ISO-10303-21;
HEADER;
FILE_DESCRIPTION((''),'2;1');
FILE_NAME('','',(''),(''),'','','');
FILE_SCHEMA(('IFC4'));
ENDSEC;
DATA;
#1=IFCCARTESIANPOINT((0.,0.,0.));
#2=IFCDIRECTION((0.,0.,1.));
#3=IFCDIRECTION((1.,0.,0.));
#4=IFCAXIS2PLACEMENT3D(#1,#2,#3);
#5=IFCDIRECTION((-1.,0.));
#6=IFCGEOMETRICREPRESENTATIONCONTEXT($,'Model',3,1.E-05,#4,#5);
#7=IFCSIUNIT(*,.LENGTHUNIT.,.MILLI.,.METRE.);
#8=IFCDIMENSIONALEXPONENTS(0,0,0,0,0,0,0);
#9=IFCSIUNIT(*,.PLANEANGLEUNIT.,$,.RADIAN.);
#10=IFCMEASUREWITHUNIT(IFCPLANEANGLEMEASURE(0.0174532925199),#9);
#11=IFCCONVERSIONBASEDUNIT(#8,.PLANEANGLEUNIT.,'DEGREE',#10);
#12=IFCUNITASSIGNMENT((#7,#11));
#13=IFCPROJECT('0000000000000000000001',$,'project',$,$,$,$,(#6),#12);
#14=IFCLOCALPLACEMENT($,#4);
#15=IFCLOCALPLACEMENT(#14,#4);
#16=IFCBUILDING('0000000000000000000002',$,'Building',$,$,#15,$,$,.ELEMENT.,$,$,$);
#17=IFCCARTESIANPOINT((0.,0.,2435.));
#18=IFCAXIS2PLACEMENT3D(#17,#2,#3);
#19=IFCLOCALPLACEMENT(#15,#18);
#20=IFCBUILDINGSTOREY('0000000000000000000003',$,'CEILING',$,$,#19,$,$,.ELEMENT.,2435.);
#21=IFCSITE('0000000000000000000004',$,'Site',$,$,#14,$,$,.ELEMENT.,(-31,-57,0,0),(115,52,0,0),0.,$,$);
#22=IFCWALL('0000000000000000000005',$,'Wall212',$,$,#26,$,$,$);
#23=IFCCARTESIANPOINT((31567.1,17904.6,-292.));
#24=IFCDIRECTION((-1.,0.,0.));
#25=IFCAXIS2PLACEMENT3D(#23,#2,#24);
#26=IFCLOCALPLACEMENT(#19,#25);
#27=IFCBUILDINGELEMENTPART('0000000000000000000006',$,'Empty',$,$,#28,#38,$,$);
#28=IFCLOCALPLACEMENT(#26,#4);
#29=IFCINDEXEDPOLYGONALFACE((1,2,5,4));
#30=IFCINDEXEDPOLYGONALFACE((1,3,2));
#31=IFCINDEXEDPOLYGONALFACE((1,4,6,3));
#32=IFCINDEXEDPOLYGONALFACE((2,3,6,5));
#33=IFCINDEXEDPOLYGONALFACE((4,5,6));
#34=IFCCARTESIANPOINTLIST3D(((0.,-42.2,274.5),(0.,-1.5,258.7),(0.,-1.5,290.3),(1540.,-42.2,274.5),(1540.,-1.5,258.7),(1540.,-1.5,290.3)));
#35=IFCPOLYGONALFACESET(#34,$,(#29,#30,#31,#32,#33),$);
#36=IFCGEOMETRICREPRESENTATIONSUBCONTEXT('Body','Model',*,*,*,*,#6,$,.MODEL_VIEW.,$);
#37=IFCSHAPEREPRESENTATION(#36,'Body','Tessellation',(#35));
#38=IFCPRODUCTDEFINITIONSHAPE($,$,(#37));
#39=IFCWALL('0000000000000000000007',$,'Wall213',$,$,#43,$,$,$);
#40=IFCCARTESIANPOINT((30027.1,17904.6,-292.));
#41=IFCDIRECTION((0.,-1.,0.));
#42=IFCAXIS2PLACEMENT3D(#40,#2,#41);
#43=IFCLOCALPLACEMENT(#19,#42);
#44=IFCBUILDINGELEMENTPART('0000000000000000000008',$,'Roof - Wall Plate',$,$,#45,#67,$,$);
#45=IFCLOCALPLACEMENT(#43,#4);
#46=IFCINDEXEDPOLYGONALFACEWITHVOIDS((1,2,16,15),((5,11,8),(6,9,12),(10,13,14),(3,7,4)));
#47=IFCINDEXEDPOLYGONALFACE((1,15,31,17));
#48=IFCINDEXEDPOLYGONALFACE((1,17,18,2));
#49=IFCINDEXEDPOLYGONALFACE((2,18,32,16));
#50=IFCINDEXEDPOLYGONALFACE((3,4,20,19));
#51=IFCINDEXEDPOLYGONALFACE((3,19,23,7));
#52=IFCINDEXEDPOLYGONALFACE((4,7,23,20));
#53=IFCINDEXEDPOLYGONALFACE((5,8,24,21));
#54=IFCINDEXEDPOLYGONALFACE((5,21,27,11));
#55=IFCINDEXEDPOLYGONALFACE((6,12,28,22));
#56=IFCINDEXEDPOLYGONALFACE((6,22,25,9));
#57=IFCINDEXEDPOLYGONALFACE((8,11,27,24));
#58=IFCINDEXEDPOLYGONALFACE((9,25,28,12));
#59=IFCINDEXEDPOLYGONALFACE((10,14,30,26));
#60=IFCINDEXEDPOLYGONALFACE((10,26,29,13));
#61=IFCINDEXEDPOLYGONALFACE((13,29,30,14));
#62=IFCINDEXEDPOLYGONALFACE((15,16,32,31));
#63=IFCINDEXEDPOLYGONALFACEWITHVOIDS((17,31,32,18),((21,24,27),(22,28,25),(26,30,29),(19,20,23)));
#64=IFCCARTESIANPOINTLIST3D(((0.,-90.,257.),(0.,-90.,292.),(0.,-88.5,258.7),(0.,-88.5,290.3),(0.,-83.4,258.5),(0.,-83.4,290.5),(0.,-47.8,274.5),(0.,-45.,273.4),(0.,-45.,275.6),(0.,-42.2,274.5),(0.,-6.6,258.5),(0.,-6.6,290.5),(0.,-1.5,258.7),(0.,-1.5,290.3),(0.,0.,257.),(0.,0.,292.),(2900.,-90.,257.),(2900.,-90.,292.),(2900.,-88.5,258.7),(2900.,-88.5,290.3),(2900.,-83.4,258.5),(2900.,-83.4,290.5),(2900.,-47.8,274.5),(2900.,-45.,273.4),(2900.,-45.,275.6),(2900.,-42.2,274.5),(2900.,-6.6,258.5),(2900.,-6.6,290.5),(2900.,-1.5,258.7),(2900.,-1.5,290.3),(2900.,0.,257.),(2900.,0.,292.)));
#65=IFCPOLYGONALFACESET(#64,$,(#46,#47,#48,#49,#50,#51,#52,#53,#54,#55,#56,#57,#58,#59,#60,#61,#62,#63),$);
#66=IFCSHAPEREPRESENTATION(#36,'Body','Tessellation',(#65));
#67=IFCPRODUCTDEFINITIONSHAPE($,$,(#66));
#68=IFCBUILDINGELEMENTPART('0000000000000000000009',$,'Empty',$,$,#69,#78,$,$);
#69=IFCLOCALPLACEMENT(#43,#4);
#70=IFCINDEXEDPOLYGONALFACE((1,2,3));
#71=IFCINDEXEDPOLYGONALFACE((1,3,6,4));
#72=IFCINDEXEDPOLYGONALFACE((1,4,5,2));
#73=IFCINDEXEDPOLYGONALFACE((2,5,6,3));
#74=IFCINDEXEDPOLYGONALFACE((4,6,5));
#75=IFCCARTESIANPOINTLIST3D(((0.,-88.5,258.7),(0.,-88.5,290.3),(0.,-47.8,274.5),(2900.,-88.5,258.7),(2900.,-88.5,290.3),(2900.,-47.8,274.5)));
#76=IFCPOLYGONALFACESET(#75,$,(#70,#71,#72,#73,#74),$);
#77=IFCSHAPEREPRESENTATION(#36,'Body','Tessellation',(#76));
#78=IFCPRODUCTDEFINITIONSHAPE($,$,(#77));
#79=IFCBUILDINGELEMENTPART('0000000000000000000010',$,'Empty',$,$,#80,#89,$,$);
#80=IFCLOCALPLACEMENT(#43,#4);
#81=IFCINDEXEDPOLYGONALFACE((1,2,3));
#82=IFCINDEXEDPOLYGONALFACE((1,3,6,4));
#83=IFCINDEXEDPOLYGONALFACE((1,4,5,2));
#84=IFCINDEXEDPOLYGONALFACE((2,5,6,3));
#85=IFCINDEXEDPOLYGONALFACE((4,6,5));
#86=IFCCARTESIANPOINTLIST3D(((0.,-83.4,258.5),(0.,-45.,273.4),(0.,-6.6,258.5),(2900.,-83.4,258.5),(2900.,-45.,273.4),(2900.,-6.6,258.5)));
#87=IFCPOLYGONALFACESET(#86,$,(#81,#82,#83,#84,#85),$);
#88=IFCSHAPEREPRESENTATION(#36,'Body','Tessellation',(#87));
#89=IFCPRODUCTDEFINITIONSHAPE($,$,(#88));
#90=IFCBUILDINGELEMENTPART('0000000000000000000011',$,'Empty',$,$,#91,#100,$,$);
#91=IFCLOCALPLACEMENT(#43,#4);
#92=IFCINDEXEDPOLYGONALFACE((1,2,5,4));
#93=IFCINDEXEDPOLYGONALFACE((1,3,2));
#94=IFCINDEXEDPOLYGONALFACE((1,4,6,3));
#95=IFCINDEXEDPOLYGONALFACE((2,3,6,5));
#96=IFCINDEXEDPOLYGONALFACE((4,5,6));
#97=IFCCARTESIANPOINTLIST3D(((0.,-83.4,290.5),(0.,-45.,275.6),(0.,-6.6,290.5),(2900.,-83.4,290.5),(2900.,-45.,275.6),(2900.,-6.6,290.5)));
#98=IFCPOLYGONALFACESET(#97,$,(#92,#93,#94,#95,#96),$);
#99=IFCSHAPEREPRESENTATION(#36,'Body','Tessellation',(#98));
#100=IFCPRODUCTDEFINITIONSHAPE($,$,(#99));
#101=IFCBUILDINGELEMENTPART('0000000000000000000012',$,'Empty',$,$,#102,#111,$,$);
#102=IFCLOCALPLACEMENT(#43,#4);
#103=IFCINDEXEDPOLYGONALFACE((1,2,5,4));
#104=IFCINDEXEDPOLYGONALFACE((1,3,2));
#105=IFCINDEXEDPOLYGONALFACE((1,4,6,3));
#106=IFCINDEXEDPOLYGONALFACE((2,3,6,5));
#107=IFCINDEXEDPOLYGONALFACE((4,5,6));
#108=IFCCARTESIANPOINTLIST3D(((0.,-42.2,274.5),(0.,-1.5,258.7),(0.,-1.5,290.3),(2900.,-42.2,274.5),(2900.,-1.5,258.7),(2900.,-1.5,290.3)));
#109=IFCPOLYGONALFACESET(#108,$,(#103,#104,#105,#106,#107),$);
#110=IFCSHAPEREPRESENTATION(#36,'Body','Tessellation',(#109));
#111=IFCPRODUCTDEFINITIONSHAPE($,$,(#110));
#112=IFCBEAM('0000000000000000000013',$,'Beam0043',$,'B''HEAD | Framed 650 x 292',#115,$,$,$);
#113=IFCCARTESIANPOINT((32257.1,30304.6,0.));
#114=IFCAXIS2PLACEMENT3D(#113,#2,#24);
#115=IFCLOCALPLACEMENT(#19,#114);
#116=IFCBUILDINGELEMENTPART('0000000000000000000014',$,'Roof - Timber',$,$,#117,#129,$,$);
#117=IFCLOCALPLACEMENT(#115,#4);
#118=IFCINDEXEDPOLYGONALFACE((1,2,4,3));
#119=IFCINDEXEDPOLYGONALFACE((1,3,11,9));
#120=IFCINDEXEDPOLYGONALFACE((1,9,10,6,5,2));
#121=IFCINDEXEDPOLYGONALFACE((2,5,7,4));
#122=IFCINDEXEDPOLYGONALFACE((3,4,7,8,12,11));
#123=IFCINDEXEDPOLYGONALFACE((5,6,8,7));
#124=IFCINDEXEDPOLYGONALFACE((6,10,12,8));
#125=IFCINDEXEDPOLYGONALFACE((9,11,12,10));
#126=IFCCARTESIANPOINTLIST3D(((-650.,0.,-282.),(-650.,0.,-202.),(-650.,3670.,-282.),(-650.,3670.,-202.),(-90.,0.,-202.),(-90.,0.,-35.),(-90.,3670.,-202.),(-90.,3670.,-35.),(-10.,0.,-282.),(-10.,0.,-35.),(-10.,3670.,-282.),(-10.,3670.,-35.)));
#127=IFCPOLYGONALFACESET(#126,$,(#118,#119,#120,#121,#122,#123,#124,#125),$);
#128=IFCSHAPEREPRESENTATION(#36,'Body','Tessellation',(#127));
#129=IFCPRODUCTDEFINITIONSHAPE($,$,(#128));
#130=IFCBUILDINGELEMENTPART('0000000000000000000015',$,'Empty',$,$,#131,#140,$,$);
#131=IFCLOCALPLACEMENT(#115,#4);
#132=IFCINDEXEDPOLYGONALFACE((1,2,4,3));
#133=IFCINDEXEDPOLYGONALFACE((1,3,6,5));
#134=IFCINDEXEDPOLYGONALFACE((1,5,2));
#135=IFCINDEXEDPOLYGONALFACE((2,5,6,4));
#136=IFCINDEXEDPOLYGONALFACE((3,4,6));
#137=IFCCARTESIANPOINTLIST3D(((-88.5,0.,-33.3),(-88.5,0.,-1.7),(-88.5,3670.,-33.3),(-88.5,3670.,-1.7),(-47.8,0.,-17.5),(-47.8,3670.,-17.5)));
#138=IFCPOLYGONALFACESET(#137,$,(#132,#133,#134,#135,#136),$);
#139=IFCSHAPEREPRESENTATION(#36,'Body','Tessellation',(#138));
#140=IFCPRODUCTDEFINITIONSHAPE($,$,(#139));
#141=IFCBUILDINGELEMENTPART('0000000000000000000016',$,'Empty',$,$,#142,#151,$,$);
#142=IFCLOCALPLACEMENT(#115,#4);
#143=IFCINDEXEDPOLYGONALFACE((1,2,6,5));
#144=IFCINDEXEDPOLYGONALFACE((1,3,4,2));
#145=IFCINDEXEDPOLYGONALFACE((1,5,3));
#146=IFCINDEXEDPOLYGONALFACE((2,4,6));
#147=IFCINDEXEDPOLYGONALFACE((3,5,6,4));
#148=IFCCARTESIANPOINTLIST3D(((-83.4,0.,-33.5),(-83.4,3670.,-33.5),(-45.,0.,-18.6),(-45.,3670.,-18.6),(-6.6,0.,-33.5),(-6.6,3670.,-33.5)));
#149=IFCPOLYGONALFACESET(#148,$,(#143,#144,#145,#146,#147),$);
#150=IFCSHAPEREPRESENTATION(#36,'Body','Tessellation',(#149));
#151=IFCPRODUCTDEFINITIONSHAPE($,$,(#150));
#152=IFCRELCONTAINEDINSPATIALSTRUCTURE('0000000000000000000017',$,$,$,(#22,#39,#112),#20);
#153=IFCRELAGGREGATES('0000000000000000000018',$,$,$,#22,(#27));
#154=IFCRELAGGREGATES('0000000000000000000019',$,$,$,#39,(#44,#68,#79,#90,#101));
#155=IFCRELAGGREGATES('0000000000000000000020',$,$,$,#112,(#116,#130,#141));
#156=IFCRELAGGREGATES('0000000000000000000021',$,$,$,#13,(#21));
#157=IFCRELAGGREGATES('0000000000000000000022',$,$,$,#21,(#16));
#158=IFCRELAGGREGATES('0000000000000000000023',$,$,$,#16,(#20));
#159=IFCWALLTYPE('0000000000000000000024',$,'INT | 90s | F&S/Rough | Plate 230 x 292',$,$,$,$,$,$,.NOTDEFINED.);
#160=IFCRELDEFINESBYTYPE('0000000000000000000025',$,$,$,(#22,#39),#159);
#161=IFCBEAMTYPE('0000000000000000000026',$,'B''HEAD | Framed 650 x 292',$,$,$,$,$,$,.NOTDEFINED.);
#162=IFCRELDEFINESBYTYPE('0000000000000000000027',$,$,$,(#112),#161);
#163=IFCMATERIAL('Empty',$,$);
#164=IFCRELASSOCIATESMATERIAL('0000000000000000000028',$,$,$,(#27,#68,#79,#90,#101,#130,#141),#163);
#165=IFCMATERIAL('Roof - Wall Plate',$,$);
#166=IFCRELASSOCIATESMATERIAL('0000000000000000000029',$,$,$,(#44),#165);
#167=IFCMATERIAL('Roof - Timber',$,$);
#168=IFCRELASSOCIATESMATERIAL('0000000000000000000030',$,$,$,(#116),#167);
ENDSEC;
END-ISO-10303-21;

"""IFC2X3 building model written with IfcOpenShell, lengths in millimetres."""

from ifc_helpers import new_model, entity, si_unit, converted_unit, direction, frame, origin_with_axes, place, context, subcontext, project, spatial, polyline, outline, extrude, material, type_object, element, aggregate, save


model = new_model("IFC2X3")

# Units and contexts
model_context = context("Model", 3, precision=1e-05, world=origin_with_axes(), true_north=direction((-1.0, 0.0)))
body_context = subcontext(model_context, "Body", "Model", "MODEL_VIEW")
ifc_project = project(units=[si_unit("LENGTHUNIT", "METRE", prefix="MILLI"), converted_unit("PLANEANGLEUNIT", "DEGREE", entity("IfcPlaneAngleMeasure", 0.0174532925199), si_unit("PLANEANGLEUNIT", "RADIAN"), dimensions=[0, 0, 0, 0, 0, 0, 0])], contexts=[model_context])

# Site, building, storey
site_placement = place(None, origin_with_axes())
site = spatial("IfcSite", under=ifc_project, at=site_placement, Name="Site", CompositionType="ELEMENT", RefLatitude=(-31, -57, 0, 0), RefLongitude=(115, 52, 0, 0), RefElevation=0.0)
building_placement = place(site_placement, origin_with_axes())
building = spatial("IfcBuilding", under=site, at=building_placement, Name="Building", CompositionType="ELEMENT")
storey_placement = place(building_placement, frame((0.0, 0.0, 2435.0), z_axis=(0.0, 0.0, 1.0), x_axis=(1.0, 0.0, 0.0)))
storey = spatial("IfcBuildingStorey", under=building, at=storey_placement, Name="CEILING", CompositionType="ELEMENT", Elevation=2435.0)

# Shared definitions
ifc_material_1 = material(Name="Roof - Timber")

# Walls, building element parts
wall_type = type_object("IfcWallType", Name="INT | 90s | F&S/Rough | Plate 230 x 292", PredefinedType="NOTDEFINED")
wall_1_placement = place(storey_placement, frame((31567.1, 17904.6, -292.0), z_axis=(0.0, 0.0, 1.0), x_axis=(-1.0, 0.0, 0.0)))
wall_1 = element("IfcWall", 1, at=wall_1_placement, inside=storey, type_object=wall_type, Name="Wall212")
ifc_material_2 = material(Name="Empty")
building_element_part_1_placement = place(wall_1_placement, origin_with_axes())
building_element_part_1 = element("IfcBuildingElementPart", 2, at=building_element_part_1_placement, material=ifc_material_2, Name="Empty", context=body_context, shape_type="SweptSolid", body=[
    extrude(outline(polyline([(-42.2, 274.5), (-1.5, 258.7), (-1.5, 290.3), (-42.2, 274.5)])), frame((0.0, 0.0, 0.0), z_axis=(1.0, 0.0, 0.0), x_axis=(0.0, 1.0, 0.0)), (0.0, 0.0, 1.0), 1540.0),
])
aggregate(wall_1, [building_element_part_1])
wall_2_placement = place(storey_placement, frame((30027.1, 17904.6, -292.0), z_axis=(0.0, 0.0, 1.0), x_axis=(0.0, -1.0, 0.0)))
wall_2 = element("IfcWall", 3, at=wall_2_placement, inside=storey, type_object=wall_type, Name="Wall213")
ifc_material_3 = material(Name="Roof - Wall Plate")
building_element_part_2_placement = place(wall_2_placement, origin_with_axes())
building_element_part_2 = element("IfcBuildingElementPart", 4, at=building_element_part_2_placement, material=ifc_material_3, Name="Roof - Wall Plate", context=body_context, shape_type="SweptSolid", body=[
    extrude(outline(polyline([(-90.0, 257.0), (0.0, 257.0), (0.0, 292.0), (-90.0, 292.0), (-90.0, 257.0)]), holes=[polyline([(-83.4, 290.5), (-6.6, 290.5), (-45.0, 275.6), (-83.4, 290.5)]), polyline([(-42.2, 274.5), (-1.5, 290.3), (-1.5, 258.7), (-42.2, 274.5)]), polyline([(-6.6, 258.5), (-83.4, 258.5), (-45.0, 273.4), (-6.6, 258.5)]), polyline([(-88.5, 258.7), (-88.5, 290.3), (-47.8, 274.5), (-88.5, 258.7)])]), frame((0.0, 0.0, 0.0), z_axis=(1.0, 0.0, 0.0), x_axis=(0.0, 1.0, 0.0)), (0.0, 0.0, 1.0), 2900.0),
])
building_element_part_3_placement = place(wall_2_placement, origin_with_axes())
building_element_part_3 = element("IfcBuildingElementPart", 5, at=building_element_part_3_placement, material=ifc_material_2, Name="Empty", context=body_context, shape_type="SweptSolid", body=[
    extrude(outline(polyline([(-47.8, 274.5), (-88.5, 290.3), (-88.5, 258.7), (-47.8, 274.5)])), frame((0.0, 0.0, 0.0), z_axis=(1.0, 0.0, 0.0), x_axis=(0.0, 1.0, 0.0)), (0.0, 0.0, 1.0), 2900.0),
])
building_element_part_4_placement = place(wall_2_placement, origin_with_axes())
building_element_part_4 = element("IfcBuildingElementPart", 6, at=building_element_part_4_placement, material=ifc_material_2, Name="Empty", context=body_context, shape_type="SweptSolid", body=[
    extrude(outline(polyline([(-6.6, 258.5), (-45.0, 273.4), (-83.4, 258.5), (-6.6, 258.5)])), frame((0.0, 0.0, 0.0), z_axis=(1.0, 0.0, 0.0), x_axis=(0.0, 1.0, 0.0)), (0.0, 0.0, 1.0), 2900.0),
])
building_element_part_5_placement = place(wall_2_placement, origin_with_axes())
building_element_part_5 = element("IfcBuildingElementPart", 7, at=building_element_part_5_placement, material=ifc_material_2, Name="Empty", context=body_context, shape_type="SweptSolid", body=[
    extrude(outline(polyline([(-45.0, 275.6), (-6.6, 290.5), (-83.4, 290.5), (-45.0, 275.6)])), frame((0.0, 0.0, 0.0), z_axis=(1.0, 0.0, 0.0), x_axis=(0.0, 1.0, 0.0)), (0.0, 0.0, 1.0), 2900.0),
])
building_element_part_6_placement = place(wall_2_placement, origin_with_axes())
building_element_part_6 = element("IfcBuildingElementPart", 8, at=building_element_part_6_placement, material=ifc_material_2, Name="Empty", context=body_context, shape_type="SweptSolid", body=[
    extrude(outline(polyline([(-42.2, 274.5), (-1.5, 258.7), (-1.5, 290.3), (-42.2, 274.5)])), frame((0.0, 0.0, 0.0), z_axis=(1.0, 0.0, 0.0), x_axis=(0.0, 1.0, 0.0)), (0.0, 0.0, 1.0), 2900.0),
])
aggregate(wall_2, [building_element_part_2, building_element_part_3, building_element_part_4, building_element_part_5, building_element_part_6])

# Beam, building element parts
beam_type = type_object("IfcBeamType", Name="B'HEAD | Framed 650 x 292", PredefinedType="NOTDEFINED")
beam_placement = place(storey_placement, frame((32257.1, 30304.6, 0.0), z_axis=(0.0, 0.0, 1.0), x_axis=(-1.0, 0.0, 0.0)))
beam = element("IfcBeam", 9, at=beam_placement, inside=storey, type_object=beam_type, Name="Beam0043", ObjectType="B'HEAD | Framed 650 x 292")
building_element_part_7_placement = place(beam_placement, origin_with_axes())
building_element_part_7 = element("IfcBuildingElementPart", 10, at=building_element_part_7_placement, material=ifc_material_1, Name="Roof - Timber", context=body_context, shape_type="SweptSolid", body=[
    extrude(outline(polyline([(-650.0, -282.0), (-10.0, -282.0), (-10.0, -35.0), (-90.0, -35.0), (-90.0, -202.0), (-650.0, -202.0), (-650.0, -282.0)])), frame((0.0, 3670.0, 0.0), z_axis=(0.0, -1.0, 0.0), x_axis=(1.0, 0.0, 0.0)), (0.0, 0.0, 1.0), 3670.0),
])
building_element_part_8_placement = place(beam_placement, origin_with_axes())
building_element_part_8 = element("IfcBuildingElementPart", 11, at=building_element_part_8_placement, material=ifc_material_2, Name="Empty", context=body_context, shape_type="SweptSolid", body=[
    extrude(outline(polyline([(-47.8, -17.5), (-88.5, -1.7), (-88.5, -33.3), (-47.8, -17.5)])), frame((0.0, 3670.0, 0.0), z_axis=(0.0, -1.0, 0.0), x_axis=(1.0, 0.0, 0.0)), (0.0, 0.0, 1.0), 3670.0),
])
building_element_part_9_placement = place(beam_placement, origin_with_axes())
building_element_part_9 = element("IfcBuildingElementPart", 12, at=building_element_part_9_placement, material=ifc_material_2, Name="Empty", context=body_context, shape_type="SweptSolid", body=[
    extrude(outline(polyline([(-6.6, -33.5), (-45.0, -18.6), (-83.4, -33.5), (-6.6, -33.5)])), frame((0.0, 3670.0, 0.0), z_axis=(0.0, -1.0, 0.0), x_axis=(1.0, 0.0, 0.0)), (0.0, 0.0, 1.0), 3670.0),
])
aggregate(beam, [building_element_part_7, building_element_part_8, building_element_part_9])

save(model, "model.ifc")
